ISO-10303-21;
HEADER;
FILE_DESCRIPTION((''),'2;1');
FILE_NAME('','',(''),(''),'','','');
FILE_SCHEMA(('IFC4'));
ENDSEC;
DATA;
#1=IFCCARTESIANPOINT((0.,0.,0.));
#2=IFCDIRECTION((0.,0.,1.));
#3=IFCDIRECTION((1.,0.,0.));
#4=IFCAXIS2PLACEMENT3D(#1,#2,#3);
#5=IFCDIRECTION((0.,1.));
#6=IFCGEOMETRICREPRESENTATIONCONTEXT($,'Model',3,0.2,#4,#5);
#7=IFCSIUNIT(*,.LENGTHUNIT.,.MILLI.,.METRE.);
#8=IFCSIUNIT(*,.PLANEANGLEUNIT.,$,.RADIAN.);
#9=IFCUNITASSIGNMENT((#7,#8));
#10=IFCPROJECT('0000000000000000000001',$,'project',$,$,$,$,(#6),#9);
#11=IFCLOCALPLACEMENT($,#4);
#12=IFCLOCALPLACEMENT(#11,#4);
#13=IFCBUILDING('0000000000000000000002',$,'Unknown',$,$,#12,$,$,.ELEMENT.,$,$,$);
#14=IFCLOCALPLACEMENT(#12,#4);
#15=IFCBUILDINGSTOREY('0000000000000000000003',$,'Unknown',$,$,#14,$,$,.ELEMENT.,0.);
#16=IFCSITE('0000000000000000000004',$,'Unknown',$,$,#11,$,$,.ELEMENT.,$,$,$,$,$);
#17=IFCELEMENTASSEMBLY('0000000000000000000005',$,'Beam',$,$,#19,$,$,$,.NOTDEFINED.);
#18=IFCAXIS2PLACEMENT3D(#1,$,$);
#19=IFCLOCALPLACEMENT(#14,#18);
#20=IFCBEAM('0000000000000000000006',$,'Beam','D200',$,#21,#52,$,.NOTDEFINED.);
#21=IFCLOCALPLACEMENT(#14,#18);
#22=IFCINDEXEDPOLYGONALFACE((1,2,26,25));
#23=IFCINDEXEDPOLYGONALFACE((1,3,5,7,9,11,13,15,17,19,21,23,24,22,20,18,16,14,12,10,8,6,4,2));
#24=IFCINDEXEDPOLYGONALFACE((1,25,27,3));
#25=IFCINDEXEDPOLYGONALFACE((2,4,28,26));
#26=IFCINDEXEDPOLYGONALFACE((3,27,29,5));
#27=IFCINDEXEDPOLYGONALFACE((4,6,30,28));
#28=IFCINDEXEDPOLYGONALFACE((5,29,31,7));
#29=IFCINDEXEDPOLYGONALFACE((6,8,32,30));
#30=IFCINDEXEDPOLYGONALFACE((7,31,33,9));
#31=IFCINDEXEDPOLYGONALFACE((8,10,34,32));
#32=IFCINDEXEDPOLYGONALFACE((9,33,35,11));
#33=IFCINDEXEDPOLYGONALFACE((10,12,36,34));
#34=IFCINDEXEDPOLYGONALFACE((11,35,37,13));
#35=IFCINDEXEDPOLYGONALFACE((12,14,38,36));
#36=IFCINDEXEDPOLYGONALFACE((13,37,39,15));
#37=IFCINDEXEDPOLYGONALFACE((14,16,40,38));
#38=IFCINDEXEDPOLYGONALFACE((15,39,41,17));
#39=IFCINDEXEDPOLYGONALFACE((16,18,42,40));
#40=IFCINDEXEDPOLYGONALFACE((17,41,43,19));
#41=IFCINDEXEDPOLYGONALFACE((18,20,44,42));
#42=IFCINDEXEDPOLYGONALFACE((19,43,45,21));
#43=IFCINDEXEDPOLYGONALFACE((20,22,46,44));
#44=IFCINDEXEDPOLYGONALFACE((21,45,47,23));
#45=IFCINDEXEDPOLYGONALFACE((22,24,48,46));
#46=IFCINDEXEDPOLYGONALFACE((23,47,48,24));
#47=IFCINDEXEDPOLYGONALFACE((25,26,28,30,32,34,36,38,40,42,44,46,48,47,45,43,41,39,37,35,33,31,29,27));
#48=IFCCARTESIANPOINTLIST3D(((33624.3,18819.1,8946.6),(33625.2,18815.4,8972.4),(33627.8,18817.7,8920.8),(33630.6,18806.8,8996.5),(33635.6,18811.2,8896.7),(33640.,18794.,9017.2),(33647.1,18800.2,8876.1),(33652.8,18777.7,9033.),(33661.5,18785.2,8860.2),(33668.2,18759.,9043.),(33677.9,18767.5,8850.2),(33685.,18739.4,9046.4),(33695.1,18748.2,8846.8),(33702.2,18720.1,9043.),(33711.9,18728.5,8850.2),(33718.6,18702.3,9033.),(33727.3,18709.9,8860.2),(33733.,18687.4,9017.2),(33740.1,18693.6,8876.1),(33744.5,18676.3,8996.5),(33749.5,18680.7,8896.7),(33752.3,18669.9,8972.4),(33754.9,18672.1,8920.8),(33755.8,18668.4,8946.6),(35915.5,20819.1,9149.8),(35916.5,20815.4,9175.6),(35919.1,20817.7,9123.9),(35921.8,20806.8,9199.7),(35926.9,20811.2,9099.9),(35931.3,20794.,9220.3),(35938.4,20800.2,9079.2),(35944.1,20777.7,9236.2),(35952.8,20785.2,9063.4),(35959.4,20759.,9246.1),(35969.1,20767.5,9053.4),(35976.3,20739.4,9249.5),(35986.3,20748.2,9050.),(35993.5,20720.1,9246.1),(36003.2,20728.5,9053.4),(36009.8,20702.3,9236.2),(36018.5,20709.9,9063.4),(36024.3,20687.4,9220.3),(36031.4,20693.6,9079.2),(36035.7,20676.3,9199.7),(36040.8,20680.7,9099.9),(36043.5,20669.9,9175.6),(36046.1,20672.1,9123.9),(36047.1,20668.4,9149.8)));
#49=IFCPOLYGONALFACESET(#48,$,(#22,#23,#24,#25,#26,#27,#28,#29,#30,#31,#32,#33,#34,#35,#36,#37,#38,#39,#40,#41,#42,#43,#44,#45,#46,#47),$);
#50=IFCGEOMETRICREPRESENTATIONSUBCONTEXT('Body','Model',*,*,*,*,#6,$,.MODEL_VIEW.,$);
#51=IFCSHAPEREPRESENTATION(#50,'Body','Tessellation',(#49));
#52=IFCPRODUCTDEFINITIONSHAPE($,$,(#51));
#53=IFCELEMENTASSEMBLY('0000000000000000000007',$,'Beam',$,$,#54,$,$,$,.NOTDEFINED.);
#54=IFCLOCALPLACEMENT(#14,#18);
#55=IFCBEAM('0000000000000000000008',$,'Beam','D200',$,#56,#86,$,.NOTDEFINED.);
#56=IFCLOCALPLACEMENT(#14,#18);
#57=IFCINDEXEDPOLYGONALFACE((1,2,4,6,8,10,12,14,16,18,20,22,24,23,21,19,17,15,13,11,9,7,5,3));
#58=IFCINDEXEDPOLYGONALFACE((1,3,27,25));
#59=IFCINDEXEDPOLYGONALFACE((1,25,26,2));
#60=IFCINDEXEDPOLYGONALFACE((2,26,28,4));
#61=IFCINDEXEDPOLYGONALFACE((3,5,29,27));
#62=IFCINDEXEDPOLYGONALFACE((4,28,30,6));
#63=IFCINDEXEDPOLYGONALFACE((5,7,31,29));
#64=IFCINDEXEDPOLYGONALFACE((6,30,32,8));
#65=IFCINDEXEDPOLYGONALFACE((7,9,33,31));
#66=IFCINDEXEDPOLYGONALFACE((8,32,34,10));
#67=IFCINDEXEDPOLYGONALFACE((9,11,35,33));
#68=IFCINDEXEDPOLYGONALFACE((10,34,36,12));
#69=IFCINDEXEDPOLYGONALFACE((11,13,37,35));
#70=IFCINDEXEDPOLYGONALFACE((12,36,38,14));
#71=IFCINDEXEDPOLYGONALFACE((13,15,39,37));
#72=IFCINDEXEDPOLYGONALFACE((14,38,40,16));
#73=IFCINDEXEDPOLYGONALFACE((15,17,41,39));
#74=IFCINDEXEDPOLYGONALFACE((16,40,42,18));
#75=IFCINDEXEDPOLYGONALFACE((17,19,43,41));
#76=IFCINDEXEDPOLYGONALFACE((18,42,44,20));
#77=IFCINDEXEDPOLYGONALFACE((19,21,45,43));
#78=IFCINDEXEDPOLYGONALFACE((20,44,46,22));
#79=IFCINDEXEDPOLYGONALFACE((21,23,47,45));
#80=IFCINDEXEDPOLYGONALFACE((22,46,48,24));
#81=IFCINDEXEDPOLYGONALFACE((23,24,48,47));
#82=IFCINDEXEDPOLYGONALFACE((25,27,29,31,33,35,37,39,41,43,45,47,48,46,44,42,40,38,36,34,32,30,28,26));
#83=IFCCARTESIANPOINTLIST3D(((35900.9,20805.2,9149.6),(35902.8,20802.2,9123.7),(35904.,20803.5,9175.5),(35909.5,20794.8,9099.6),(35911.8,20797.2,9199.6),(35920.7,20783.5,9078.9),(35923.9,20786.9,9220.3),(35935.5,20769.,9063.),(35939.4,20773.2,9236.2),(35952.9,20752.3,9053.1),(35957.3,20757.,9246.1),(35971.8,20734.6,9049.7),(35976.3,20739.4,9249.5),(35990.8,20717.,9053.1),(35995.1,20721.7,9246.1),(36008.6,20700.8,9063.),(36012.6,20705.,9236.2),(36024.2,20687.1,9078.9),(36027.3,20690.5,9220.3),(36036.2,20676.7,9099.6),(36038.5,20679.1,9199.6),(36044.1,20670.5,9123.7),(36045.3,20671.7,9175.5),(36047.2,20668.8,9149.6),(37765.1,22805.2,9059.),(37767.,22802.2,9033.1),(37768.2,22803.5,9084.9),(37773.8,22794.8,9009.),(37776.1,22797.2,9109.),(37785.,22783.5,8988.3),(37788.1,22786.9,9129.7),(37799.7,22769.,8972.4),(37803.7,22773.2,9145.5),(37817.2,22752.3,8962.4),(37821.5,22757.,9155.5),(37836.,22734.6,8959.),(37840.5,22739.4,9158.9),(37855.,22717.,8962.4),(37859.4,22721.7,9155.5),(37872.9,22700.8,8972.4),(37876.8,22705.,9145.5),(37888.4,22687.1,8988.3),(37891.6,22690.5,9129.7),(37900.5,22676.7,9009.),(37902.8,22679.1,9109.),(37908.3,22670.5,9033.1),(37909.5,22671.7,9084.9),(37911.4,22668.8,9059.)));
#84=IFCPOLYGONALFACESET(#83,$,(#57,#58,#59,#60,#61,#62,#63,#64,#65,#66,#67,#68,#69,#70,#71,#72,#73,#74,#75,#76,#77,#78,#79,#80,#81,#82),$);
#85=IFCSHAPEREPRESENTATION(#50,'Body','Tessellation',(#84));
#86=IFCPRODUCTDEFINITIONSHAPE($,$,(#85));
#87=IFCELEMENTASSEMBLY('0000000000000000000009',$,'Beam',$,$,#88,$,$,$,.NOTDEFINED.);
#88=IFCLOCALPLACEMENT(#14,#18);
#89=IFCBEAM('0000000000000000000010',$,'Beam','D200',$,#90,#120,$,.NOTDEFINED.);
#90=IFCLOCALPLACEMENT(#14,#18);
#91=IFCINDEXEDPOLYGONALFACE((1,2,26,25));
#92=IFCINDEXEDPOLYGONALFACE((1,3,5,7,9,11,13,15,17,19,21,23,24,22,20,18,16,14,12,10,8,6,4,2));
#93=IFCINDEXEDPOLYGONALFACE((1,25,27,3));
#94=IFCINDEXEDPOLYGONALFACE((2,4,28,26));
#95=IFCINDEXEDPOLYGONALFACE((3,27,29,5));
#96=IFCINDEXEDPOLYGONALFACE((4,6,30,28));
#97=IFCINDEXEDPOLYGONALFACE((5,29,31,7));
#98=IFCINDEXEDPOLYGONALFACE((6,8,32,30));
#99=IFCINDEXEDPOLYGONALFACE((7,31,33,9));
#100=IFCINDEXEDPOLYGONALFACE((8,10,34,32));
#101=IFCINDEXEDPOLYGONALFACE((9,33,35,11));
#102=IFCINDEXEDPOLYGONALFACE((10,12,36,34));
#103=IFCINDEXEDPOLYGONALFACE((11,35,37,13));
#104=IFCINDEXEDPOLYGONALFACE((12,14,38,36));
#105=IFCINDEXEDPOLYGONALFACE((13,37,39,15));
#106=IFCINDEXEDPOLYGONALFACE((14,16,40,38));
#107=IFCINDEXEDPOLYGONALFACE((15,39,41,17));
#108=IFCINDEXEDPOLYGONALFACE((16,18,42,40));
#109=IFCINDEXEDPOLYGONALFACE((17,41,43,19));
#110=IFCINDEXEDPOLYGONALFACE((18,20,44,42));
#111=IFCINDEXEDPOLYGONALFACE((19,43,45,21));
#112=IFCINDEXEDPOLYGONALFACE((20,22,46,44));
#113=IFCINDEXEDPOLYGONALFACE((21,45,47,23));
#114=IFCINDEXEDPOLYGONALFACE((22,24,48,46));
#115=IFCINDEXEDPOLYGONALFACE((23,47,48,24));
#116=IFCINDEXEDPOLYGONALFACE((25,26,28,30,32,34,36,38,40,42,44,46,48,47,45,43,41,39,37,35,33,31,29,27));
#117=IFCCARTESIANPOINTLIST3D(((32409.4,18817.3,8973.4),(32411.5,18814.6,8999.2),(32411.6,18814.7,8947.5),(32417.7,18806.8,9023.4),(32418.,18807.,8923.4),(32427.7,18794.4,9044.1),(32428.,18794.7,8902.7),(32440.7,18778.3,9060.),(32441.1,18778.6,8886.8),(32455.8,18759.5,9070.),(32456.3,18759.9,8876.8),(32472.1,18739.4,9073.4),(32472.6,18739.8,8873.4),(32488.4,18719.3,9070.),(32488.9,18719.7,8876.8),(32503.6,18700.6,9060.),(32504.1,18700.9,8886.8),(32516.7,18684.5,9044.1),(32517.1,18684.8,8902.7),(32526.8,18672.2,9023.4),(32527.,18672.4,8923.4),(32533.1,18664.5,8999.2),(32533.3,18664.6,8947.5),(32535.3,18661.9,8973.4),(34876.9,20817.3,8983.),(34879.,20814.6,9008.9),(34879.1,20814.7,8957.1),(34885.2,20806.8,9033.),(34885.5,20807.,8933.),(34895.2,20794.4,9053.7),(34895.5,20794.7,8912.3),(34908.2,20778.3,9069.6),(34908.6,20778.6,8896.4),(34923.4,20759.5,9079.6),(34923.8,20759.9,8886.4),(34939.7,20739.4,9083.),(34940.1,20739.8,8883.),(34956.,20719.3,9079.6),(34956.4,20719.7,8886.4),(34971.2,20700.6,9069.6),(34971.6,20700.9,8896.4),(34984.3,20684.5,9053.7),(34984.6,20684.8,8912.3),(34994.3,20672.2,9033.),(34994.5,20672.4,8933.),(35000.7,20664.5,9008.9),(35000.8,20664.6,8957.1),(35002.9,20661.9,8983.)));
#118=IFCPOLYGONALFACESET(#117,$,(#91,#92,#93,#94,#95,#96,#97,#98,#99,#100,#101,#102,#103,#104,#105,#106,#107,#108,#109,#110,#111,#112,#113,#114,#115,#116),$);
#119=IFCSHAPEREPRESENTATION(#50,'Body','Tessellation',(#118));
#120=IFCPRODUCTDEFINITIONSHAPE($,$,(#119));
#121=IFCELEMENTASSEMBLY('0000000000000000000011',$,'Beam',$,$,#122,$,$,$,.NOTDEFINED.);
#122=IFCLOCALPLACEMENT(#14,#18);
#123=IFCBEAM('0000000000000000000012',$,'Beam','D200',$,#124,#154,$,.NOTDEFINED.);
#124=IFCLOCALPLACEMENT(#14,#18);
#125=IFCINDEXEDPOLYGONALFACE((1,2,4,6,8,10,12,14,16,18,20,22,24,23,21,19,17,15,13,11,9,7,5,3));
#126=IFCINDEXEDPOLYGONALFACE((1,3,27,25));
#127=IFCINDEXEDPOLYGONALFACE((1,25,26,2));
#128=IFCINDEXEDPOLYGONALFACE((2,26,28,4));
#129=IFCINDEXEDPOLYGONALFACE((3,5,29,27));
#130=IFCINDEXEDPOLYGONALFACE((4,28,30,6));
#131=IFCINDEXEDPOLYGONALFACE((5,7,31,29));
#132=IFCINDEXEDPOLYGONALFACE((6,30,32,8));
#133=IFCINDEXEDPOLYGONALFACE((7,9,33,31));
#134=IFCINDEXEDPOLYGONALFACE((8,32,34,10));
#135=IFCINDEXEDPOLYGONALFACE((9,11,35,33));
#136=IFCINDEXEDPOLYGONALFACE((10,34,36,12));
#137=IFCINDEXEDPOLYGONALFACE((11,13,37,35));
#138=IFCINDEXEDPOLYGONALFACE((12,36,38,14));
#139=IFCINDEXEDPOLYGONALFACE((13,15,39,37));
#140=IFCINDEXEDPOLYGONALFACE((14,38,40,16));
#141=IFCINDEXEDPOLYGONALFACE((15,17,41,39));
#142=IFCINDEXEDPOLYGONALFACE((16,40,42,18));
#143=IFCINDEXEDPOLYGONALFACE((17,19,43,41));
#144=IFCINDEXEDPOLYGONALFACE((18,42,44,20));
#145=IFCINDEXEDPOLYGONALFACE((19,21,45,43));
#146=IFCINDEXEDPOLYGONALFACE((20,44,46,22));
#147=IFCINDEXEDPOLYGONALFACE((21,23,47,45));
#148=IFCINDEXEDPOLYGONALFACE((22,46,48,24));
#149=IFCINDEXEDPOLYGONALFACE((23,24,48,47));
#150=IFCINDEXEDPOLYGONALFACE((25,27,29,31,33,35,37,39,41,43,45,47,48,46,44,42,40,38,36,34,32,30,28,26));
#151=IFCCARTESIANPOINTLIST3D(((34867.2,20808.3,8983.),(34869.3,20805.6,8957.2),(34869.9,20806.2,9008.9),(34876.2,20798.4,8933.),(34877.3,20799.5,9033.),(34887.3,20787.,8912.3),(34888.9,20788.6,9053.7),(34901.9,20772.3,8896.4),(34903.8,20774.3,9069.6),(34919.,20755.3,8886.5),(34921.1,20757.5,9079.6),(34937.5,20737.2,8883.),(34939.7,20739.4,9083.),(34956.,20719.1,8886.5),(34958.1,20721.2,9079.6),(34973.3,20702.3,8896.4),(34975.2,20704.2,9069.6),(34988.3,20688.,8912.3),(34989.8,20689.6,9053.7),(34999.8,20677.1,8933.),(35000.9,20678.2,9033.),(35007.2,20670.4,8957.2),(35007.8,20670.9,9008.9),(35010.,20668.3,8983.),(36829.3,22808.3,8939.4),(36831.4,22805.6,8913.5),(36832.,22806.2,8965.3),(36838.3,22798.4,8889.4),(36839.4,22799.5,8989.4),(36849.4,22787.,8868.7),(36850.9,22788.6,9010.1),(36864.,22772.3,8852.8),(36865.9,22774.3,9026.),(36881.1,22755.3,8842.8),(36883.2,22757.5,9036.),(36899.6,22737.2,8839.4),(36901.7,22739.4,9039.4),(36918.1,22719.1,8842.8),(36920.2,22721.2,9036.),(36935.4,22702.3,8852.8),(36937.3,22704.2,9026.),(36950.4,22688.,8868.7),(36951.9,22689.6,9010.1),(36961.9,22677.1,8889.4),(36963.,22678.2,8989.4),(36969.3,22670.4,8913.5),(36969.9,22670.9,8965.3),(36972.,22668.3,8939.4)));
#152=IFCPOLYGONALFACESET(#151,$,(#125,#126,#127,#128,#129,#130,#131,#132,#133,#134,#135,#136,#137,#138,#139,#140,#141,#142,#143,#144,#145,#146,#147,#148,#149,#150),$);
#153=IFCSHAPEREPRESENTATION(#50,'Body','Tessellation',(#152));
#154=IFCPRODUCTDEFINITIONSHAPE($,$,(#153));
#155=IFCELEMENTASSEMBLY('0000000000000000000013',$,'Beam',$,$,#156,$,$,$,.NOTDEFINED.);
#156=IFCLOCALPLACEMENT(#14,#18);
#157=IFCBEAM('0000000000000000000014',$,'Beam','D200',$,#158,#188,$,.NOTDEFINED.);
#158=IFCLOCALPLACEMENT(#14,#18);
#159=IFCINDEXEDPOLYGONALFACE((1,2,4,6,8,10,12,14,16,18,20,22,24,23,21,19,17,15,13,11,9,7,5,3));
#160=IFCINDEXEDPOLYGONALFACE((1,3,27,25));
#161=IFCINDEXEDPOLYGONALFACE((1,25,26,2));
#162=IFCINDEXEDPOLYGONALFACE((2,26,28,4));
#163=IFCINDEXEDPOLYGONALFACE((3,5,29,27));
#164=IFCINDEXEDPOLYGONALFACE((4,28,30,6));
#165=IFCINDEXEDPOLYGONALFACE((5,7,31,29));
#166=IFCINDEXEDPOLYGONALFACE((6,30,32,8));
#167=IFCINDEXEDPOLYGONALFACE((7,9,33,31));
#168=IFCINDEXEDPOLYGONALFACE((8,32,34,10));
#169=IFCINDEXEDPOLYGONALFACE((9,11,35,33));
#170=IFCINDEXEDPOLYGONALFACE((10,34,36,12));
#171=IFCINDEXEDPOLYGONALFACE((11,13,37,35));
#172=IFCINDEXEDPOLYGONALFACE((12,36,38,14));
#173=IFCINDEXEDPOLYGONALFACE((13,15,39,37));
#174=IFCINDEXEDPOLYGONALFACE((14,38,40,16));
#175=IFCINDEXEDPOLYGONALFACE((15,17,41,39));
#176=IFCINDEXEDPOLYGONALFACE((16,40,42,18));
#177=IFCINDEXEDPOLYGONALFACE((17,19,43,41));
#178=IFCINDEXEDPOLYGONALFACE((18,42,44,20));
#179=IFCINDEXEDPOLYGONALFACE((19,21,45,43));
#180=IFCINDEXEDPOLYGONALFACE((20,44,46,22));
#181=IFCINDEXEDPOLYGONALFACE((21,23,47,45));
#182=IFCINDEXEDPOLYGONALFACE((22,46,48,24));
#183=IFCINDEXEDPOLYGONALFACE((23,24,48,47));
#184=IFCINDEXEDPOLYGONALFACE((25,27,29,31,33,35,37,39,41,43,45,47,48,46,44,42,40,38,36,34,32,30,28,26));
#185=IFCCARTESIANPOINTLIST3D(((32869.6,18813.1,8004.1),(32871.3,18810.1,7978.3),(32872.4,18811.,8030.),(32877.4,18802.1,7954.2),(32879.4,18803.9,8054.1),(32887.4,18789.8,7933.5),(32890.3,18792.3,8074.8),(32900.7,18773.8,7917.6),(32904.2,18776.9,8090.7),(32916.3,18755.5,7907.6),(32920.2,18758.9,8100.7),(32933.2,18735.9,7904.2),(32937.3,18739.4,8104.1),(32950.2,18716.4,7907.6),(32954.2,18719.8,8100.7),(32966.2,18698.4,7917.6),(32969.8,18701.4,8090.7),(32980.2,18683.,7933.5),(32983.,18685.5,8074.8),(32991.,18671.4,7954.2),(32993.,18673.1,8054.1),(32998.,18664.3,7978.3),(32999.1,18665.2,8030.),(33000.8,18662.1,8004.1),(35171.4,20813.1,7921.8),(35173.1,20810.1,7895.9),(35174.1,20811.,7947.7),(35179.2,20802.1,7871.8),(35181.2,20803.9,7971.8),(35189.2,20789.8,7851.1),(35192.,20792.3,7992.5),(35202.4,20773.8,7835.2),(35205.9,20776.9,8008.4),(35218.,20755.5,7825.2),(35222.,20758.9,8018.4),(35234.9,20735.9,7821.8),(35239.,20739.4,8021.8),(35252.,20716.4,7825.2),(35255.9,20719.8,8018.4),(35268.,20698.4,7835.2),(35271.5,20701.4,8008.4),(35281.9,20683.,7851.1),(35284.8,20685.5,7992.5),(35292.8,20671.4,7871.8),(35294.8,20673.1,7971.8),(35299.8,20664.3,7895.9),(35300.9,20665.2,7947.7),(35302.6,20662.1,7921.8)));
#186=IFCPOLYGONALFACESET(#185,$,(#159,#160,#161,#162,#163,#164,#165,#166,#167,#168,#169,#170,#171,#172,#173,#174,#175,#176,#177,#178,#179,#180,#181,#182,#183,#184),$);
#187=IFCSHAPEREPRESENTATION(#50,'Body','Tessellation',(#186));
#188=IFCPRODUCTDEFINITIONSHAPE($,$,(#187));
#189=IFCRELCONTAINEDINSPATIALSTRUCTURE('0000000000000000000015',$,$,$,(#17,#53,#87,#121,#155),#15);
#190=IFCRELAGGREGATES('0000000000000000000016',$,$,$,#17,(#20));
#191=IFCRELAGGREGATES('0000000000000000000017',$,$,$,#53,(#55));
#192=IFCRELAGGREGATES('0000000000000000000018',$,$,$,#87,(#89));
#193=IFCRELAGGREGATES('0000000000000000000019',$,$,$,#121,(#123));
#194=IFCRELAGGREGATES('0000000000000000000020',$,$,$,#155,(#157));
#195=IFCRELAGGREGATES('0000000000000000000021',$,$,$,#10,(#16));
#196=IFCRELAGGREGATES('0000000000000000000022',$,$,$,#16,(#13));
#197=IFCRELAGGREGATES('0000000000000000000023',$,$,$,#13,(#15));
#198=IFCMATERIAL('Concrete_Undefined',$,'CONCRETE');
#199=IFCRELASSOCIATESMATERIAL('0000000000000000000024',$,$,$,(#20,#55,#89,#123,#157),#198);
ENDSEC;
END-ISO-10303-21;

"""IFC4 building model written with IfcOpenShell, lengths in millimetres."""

from ifc_helpers import new_model, si_unit, direction, frame, origin_with_axes, place, context, subcontext, project, spatial, line, indexed_curve, outline, extrude, material, element, aggregate, save


model = new_model("IFC4")

# Units and contexts
model_context = context("Model", 3, precision=0.2, world=origin_with_axes(), true_north=direction((0.0, 1.0)))
body_context = subcontext(model_context, "Body", "Model", "MODEL_VIEW")
ifc_project = project(units=[si_unit("LENGTHUNIT", "METRE", prefix="MILLI"), si_unit("PLANEANGLEUNIT", "RADIAN")], contexts=[model_context])

# Site, building, storey
site_placement = place(None, origin_with_axes())
site = spatial("IfcSite", under=ifc_project, at=site_placement, Name="Unknown", CompositionType="ELEMENT")
building_placement = place(site_placement, origin_with_axes())
building = spatial("IfcBuilding", under=site, at=building_placement, Name="Unknown", CompositionType="ELEMENT")
storey_placement = place(building_placement, origin_with_axes())
storey = spatial("IfcBuildingStorey", under=building, at=storey_placement, Name="Unknown", CompositionType="ELEMENT", Elevation=0.0)

# Element assemblies, beams
ifc_material = material(Name="Concrete_Undefined", Category="CONCRETE")
assembly_1_placement = place(storey_placement, frame((35981.3, 20743.8, 9149.8), z_axis=(-0.657601, 0.753367, 0.0), x_axis=(-0.751691, -0.656138, -0.06665)))
assembly_1 = element("IfcElementAssembly", 1, at=assembly_1_placement, inside=storey, Name="Beam", PredefinedType="NOTDEFINED")
beam_1_placement = place(assembly_1_placement, origin_with_axes())
beam_1 = element("IfcBeam", 2, at=beam_1_placement, material=ifc_material, Name="Beam", Description="D200", PredefinedType="NOTDEFINED", context=body_context, shape_type="SolidModel", body=[
    extrude(outline(indexed_curve([(100.0, 0.0), (96.6, 25.9), (86.6, 50.0), (70.7, 70.7), (50.0, 86.6), (25.9, 96.6), (0.0, 100.0), (-25.9, 96.6), (-50.0, 86.6), (-70.7, 70.7), (-86.6, 50.0), (-96.6, 25.9), (-100.0, 0.0), (-96.6, -25.9), (-86.6, -50.0), (-70.7, -70.7), (-50.0, -86.6), (-25.9, -96.6), (0.0, -100.0), (25.9, -96.6), (50.0, -86.6), (70.7, -70.7), (86.6, -50.0), (96.6, -25.9)], segments=[line(1, 2, 3, 4, 5, 6, 7, 8, 9, 10, 11, 12, 13, 14, 15, 16, 17, 18, 19, 20, 21, 22, 23, 24, 1)])), frame((0.0, 0.0, 0.0), z_axis=(-1.0, 0.0, 0.0), x_axis=(0.0, 0.0, 1.0)), (0.0, 0.0, -1.0), 3048.1),
])
aggregate(assembly_1, [beam_1])
assembly_2_placement = place(storey_placement, frame((37838.3, 22737.0, 9059.0), z_axis=(-0.731496, 0.681846, 0.0), x_axis=(-0.681472, -0.731094, 0.033121)))
assembly_2 = element("IfcElementAssembly", 3, at=assembly_2_placement, inside=storey, Name="Beam", PredefinedType="NOTDEFINED")
beam_2_placement = place(assembly_2_placement, origin_with_axes())
beam_2 = element("IfcBeam", 4, at=beam_2_placement, material=ifc_material, Name="Beam", Description="D200", PredefinedType="NOTDEFINED", context=body_context, shape_type="SolidModel", body=[
    extrude(outline(indexed_curve([(100.0, 0.0), (96.6, 25.9), (86.6, 50.0), (70.7, 70.7), (50.0, 86.6), (25.9, 96.6), (0.0, 100.0), (-25.9, 96.6), (-50.0, 86.6), (-70.7, 70.7), (-86.6, 50.0), (-96.6, 25.9), (-100.0, 0.0), (-96.6, -25.9), (-86.6, -50.0), (-70.7, -70.7), (-50.0, -86.6), (-25.9, -96.6), (0.0, -100.0), (25.9, -96.6), (50.0, -86.6), (70.7, -70.7), (86.6, -50.0), (96.6, -25.9)], segments=[line(1, 2, 3, 4, 5, 6, 7, 8, 9, 10, 11, 12, 13, 14, 15, 16, 17, 18, 19, 20, 21, 22, 23, 24, 1)])), frame((0.0, 0.0, 0.0), z_axis=(-1.0, 0.0, 0.0), x_axis=(0.0, 0.0, 1.0)), (0.0, 0.0, -1.0), 2735.6),
])
aggregate(assembly_2, [beam_2])
assembly_3_placement = place(storey_placement, frame((34939.9, 20739.6, 8983.0), z_axis=(-0.62967, 0.776863, 0.0), x_axis=(-0.776859, -0.629667, -0.003042)))
assembly_3 = element("IfcElementAssembly", 5, at=assembly_3_placement, inside=storey, Name="Beam", PredefinedType="NOTDEFINED")
beam_3_placement = place(assembly_3_placement, origin_with_axes())
beam_3 = element("IfcBeam", 6, at=beam_3_placement, material=ifc_material, Name="Beam", Description="D200", PredefinedType="NOTDEFINED", context=body_context, shape_type="SolidModel", body=[
    extrude(outline(indexed_curve([(100.0, 0.0), (96.6, 25.9), (86.6, 50.0), (70.7, 70.7), (50.0, 86.6), (25.9, 96.6), (0.0, 100.0), (-25.9, 96.6), (-50.0, 86.6), (-70.7, 70.7), (-86.6, 50.0), (-96.6, 25.9), (-100.0, 0.0), (-96.6, -25.9), (-86.6, -50.0), (-70.7, -70.7), (-50.0, -86.6), (-25.9, -96.6), (0.0, -100.0), (25.9, -96.6), (50.0, -86.6), (70.7, -70.7), (86.6, -50.0), (96.6, -25.9)], segments=[line(1, 2, 3, 4, 5, 6, 7, 8, 9, 10, 11, 12, 13, 14, 15, 16, 17, 18, 19, 20, 21, 22, 23, 24, 1)])), frame((0.0, 0.0, 0.0), z_axis=(-1.0, 0.0, 0.0), x_axis=(0.0, 0.0, 1.0)), (0.0, 0.0, -1.0), 3176.3),
])
aggregate(assembly_3, [beam_3])
assembly_4_placement = place(storey_placement, frame((36900.6, 22738.3, 8939.4), z_axis=(-0.713842, 0.700307, 0.0), x_axis=(-0.700222, -0.713755, 0.015569)))
assembly_4 = element("IfcElementAssembly", 7, at=assembly_4_placement, inside=storey, Name="Beam", PredefinedType="NOTDEFINED")
beam_4_placement = place(assembly_4_placement, origin_with_axes())
beam_4 = element("IfcBeam", 8, at=beam_4_placement, material=ifc_material, Name="Beam", Description="D200", PredefinedType="NOTDEFINED", context=body_context, shape_type="SolidModel", body=[
    extrude(outline(indexed_curve([(100.0, 0.0), (96.6, 25.9), (86.6, 50.0), (70.7, 70.7), (50.0, 86.6), (25.9, 96.6), (0.0, 100.0), (-25.9, 96.6), (-50.0, 86.6), (-70.7, 70.7), (-86.6, 50.0), (-96.6, 25.9), (-100.0, 0.0), (-96.6, -25.9), (-86.6, -50.0), (-70.7, -70.7), (-50.0, -86.6), (-25.9, -96.6), (0.0, -100.0), (25.9, -96.6), (50.0, -86.6), (70.7, -70.7), (86.6, -50.0), (96.6, -25.9)], segments=[line(1, 2, 3, 4, 5, 6, 7, 8, 9, 10, 11, 12, 13, 14, 15, 16, 17, 18, 19, 20, 21, 22, 23, 24, 1)])), frame((0.0, 0.0, 0.0), z_axis=(-1.0, 0.0, 0.0), x_axis=(0.0, 0.0, 1.0)), (0.0, 0.0, -1.0), 2802.1),
])
aggregate(assembly_4, [beam_4])
assembly_5_placement = place(storey_placement, frame((35237.0, 20737.6, 7921.8), z_axis=(-0.655894, 0.754853, 0.0), x_axis=(-0.754578, -0.655655, 0.026992)))
assembly_5 = element("IfcElementAssembly", 9, at=assembly_5_placement, inside=storey, Name="Beam", PredefinedType="NOTDEFINED")
beam_5_placement = place(assembly_5_placement, origin_with_axes())
beam_5 = element("IfcBeam", 10, at=beam_5_placement, material=ifc_material, Name="Beam", Description="D200", PredefinedType="NOTDEFINED", context=body_context, shape_type="SolidModel", body=[
    extrude(outline(indexed_curve([(100.0, 0.0), (96.6, 25.9), (86.6, 50.0), (70.7, 70.7), (50.0, 86.6), (25.9, 96.6), (0.0, 100.0), (-25.9, 96.6), (-50.0, 86.6), (-70.7, 70.7), (-86.6, 50.0), (-96.6, 25.9), (-100.0, 0.0), (-96.6, -25.9), (-86.6, -50.0), (-70.7, -70.7), (-50.0, -86.6), (-25.9, -96.6), (0.0, -100.0), (25.9, -96.6), (50.0, -86.6), (70.7, -70.7), (86.6, -50.0), (96.6, -25.9)], segments=[line(1, 2, 3, 4, 5, 6, 7, 8, 9, 10, 11, 12, 13, 14, 15, 16, 17, 18, 19, 20, 21, 22, 23, 24, 1)])), frame((0.0, 0.0, 0.0), z_axis=(-1.0, 0.0, 0.0), x_axis=(0.0, 0.0, 1.0)), (0.0, 0.0, -1.0), 3050.4),
])
aggregate(assembly_5, [beam_5])

save(model, "model.ifc")
